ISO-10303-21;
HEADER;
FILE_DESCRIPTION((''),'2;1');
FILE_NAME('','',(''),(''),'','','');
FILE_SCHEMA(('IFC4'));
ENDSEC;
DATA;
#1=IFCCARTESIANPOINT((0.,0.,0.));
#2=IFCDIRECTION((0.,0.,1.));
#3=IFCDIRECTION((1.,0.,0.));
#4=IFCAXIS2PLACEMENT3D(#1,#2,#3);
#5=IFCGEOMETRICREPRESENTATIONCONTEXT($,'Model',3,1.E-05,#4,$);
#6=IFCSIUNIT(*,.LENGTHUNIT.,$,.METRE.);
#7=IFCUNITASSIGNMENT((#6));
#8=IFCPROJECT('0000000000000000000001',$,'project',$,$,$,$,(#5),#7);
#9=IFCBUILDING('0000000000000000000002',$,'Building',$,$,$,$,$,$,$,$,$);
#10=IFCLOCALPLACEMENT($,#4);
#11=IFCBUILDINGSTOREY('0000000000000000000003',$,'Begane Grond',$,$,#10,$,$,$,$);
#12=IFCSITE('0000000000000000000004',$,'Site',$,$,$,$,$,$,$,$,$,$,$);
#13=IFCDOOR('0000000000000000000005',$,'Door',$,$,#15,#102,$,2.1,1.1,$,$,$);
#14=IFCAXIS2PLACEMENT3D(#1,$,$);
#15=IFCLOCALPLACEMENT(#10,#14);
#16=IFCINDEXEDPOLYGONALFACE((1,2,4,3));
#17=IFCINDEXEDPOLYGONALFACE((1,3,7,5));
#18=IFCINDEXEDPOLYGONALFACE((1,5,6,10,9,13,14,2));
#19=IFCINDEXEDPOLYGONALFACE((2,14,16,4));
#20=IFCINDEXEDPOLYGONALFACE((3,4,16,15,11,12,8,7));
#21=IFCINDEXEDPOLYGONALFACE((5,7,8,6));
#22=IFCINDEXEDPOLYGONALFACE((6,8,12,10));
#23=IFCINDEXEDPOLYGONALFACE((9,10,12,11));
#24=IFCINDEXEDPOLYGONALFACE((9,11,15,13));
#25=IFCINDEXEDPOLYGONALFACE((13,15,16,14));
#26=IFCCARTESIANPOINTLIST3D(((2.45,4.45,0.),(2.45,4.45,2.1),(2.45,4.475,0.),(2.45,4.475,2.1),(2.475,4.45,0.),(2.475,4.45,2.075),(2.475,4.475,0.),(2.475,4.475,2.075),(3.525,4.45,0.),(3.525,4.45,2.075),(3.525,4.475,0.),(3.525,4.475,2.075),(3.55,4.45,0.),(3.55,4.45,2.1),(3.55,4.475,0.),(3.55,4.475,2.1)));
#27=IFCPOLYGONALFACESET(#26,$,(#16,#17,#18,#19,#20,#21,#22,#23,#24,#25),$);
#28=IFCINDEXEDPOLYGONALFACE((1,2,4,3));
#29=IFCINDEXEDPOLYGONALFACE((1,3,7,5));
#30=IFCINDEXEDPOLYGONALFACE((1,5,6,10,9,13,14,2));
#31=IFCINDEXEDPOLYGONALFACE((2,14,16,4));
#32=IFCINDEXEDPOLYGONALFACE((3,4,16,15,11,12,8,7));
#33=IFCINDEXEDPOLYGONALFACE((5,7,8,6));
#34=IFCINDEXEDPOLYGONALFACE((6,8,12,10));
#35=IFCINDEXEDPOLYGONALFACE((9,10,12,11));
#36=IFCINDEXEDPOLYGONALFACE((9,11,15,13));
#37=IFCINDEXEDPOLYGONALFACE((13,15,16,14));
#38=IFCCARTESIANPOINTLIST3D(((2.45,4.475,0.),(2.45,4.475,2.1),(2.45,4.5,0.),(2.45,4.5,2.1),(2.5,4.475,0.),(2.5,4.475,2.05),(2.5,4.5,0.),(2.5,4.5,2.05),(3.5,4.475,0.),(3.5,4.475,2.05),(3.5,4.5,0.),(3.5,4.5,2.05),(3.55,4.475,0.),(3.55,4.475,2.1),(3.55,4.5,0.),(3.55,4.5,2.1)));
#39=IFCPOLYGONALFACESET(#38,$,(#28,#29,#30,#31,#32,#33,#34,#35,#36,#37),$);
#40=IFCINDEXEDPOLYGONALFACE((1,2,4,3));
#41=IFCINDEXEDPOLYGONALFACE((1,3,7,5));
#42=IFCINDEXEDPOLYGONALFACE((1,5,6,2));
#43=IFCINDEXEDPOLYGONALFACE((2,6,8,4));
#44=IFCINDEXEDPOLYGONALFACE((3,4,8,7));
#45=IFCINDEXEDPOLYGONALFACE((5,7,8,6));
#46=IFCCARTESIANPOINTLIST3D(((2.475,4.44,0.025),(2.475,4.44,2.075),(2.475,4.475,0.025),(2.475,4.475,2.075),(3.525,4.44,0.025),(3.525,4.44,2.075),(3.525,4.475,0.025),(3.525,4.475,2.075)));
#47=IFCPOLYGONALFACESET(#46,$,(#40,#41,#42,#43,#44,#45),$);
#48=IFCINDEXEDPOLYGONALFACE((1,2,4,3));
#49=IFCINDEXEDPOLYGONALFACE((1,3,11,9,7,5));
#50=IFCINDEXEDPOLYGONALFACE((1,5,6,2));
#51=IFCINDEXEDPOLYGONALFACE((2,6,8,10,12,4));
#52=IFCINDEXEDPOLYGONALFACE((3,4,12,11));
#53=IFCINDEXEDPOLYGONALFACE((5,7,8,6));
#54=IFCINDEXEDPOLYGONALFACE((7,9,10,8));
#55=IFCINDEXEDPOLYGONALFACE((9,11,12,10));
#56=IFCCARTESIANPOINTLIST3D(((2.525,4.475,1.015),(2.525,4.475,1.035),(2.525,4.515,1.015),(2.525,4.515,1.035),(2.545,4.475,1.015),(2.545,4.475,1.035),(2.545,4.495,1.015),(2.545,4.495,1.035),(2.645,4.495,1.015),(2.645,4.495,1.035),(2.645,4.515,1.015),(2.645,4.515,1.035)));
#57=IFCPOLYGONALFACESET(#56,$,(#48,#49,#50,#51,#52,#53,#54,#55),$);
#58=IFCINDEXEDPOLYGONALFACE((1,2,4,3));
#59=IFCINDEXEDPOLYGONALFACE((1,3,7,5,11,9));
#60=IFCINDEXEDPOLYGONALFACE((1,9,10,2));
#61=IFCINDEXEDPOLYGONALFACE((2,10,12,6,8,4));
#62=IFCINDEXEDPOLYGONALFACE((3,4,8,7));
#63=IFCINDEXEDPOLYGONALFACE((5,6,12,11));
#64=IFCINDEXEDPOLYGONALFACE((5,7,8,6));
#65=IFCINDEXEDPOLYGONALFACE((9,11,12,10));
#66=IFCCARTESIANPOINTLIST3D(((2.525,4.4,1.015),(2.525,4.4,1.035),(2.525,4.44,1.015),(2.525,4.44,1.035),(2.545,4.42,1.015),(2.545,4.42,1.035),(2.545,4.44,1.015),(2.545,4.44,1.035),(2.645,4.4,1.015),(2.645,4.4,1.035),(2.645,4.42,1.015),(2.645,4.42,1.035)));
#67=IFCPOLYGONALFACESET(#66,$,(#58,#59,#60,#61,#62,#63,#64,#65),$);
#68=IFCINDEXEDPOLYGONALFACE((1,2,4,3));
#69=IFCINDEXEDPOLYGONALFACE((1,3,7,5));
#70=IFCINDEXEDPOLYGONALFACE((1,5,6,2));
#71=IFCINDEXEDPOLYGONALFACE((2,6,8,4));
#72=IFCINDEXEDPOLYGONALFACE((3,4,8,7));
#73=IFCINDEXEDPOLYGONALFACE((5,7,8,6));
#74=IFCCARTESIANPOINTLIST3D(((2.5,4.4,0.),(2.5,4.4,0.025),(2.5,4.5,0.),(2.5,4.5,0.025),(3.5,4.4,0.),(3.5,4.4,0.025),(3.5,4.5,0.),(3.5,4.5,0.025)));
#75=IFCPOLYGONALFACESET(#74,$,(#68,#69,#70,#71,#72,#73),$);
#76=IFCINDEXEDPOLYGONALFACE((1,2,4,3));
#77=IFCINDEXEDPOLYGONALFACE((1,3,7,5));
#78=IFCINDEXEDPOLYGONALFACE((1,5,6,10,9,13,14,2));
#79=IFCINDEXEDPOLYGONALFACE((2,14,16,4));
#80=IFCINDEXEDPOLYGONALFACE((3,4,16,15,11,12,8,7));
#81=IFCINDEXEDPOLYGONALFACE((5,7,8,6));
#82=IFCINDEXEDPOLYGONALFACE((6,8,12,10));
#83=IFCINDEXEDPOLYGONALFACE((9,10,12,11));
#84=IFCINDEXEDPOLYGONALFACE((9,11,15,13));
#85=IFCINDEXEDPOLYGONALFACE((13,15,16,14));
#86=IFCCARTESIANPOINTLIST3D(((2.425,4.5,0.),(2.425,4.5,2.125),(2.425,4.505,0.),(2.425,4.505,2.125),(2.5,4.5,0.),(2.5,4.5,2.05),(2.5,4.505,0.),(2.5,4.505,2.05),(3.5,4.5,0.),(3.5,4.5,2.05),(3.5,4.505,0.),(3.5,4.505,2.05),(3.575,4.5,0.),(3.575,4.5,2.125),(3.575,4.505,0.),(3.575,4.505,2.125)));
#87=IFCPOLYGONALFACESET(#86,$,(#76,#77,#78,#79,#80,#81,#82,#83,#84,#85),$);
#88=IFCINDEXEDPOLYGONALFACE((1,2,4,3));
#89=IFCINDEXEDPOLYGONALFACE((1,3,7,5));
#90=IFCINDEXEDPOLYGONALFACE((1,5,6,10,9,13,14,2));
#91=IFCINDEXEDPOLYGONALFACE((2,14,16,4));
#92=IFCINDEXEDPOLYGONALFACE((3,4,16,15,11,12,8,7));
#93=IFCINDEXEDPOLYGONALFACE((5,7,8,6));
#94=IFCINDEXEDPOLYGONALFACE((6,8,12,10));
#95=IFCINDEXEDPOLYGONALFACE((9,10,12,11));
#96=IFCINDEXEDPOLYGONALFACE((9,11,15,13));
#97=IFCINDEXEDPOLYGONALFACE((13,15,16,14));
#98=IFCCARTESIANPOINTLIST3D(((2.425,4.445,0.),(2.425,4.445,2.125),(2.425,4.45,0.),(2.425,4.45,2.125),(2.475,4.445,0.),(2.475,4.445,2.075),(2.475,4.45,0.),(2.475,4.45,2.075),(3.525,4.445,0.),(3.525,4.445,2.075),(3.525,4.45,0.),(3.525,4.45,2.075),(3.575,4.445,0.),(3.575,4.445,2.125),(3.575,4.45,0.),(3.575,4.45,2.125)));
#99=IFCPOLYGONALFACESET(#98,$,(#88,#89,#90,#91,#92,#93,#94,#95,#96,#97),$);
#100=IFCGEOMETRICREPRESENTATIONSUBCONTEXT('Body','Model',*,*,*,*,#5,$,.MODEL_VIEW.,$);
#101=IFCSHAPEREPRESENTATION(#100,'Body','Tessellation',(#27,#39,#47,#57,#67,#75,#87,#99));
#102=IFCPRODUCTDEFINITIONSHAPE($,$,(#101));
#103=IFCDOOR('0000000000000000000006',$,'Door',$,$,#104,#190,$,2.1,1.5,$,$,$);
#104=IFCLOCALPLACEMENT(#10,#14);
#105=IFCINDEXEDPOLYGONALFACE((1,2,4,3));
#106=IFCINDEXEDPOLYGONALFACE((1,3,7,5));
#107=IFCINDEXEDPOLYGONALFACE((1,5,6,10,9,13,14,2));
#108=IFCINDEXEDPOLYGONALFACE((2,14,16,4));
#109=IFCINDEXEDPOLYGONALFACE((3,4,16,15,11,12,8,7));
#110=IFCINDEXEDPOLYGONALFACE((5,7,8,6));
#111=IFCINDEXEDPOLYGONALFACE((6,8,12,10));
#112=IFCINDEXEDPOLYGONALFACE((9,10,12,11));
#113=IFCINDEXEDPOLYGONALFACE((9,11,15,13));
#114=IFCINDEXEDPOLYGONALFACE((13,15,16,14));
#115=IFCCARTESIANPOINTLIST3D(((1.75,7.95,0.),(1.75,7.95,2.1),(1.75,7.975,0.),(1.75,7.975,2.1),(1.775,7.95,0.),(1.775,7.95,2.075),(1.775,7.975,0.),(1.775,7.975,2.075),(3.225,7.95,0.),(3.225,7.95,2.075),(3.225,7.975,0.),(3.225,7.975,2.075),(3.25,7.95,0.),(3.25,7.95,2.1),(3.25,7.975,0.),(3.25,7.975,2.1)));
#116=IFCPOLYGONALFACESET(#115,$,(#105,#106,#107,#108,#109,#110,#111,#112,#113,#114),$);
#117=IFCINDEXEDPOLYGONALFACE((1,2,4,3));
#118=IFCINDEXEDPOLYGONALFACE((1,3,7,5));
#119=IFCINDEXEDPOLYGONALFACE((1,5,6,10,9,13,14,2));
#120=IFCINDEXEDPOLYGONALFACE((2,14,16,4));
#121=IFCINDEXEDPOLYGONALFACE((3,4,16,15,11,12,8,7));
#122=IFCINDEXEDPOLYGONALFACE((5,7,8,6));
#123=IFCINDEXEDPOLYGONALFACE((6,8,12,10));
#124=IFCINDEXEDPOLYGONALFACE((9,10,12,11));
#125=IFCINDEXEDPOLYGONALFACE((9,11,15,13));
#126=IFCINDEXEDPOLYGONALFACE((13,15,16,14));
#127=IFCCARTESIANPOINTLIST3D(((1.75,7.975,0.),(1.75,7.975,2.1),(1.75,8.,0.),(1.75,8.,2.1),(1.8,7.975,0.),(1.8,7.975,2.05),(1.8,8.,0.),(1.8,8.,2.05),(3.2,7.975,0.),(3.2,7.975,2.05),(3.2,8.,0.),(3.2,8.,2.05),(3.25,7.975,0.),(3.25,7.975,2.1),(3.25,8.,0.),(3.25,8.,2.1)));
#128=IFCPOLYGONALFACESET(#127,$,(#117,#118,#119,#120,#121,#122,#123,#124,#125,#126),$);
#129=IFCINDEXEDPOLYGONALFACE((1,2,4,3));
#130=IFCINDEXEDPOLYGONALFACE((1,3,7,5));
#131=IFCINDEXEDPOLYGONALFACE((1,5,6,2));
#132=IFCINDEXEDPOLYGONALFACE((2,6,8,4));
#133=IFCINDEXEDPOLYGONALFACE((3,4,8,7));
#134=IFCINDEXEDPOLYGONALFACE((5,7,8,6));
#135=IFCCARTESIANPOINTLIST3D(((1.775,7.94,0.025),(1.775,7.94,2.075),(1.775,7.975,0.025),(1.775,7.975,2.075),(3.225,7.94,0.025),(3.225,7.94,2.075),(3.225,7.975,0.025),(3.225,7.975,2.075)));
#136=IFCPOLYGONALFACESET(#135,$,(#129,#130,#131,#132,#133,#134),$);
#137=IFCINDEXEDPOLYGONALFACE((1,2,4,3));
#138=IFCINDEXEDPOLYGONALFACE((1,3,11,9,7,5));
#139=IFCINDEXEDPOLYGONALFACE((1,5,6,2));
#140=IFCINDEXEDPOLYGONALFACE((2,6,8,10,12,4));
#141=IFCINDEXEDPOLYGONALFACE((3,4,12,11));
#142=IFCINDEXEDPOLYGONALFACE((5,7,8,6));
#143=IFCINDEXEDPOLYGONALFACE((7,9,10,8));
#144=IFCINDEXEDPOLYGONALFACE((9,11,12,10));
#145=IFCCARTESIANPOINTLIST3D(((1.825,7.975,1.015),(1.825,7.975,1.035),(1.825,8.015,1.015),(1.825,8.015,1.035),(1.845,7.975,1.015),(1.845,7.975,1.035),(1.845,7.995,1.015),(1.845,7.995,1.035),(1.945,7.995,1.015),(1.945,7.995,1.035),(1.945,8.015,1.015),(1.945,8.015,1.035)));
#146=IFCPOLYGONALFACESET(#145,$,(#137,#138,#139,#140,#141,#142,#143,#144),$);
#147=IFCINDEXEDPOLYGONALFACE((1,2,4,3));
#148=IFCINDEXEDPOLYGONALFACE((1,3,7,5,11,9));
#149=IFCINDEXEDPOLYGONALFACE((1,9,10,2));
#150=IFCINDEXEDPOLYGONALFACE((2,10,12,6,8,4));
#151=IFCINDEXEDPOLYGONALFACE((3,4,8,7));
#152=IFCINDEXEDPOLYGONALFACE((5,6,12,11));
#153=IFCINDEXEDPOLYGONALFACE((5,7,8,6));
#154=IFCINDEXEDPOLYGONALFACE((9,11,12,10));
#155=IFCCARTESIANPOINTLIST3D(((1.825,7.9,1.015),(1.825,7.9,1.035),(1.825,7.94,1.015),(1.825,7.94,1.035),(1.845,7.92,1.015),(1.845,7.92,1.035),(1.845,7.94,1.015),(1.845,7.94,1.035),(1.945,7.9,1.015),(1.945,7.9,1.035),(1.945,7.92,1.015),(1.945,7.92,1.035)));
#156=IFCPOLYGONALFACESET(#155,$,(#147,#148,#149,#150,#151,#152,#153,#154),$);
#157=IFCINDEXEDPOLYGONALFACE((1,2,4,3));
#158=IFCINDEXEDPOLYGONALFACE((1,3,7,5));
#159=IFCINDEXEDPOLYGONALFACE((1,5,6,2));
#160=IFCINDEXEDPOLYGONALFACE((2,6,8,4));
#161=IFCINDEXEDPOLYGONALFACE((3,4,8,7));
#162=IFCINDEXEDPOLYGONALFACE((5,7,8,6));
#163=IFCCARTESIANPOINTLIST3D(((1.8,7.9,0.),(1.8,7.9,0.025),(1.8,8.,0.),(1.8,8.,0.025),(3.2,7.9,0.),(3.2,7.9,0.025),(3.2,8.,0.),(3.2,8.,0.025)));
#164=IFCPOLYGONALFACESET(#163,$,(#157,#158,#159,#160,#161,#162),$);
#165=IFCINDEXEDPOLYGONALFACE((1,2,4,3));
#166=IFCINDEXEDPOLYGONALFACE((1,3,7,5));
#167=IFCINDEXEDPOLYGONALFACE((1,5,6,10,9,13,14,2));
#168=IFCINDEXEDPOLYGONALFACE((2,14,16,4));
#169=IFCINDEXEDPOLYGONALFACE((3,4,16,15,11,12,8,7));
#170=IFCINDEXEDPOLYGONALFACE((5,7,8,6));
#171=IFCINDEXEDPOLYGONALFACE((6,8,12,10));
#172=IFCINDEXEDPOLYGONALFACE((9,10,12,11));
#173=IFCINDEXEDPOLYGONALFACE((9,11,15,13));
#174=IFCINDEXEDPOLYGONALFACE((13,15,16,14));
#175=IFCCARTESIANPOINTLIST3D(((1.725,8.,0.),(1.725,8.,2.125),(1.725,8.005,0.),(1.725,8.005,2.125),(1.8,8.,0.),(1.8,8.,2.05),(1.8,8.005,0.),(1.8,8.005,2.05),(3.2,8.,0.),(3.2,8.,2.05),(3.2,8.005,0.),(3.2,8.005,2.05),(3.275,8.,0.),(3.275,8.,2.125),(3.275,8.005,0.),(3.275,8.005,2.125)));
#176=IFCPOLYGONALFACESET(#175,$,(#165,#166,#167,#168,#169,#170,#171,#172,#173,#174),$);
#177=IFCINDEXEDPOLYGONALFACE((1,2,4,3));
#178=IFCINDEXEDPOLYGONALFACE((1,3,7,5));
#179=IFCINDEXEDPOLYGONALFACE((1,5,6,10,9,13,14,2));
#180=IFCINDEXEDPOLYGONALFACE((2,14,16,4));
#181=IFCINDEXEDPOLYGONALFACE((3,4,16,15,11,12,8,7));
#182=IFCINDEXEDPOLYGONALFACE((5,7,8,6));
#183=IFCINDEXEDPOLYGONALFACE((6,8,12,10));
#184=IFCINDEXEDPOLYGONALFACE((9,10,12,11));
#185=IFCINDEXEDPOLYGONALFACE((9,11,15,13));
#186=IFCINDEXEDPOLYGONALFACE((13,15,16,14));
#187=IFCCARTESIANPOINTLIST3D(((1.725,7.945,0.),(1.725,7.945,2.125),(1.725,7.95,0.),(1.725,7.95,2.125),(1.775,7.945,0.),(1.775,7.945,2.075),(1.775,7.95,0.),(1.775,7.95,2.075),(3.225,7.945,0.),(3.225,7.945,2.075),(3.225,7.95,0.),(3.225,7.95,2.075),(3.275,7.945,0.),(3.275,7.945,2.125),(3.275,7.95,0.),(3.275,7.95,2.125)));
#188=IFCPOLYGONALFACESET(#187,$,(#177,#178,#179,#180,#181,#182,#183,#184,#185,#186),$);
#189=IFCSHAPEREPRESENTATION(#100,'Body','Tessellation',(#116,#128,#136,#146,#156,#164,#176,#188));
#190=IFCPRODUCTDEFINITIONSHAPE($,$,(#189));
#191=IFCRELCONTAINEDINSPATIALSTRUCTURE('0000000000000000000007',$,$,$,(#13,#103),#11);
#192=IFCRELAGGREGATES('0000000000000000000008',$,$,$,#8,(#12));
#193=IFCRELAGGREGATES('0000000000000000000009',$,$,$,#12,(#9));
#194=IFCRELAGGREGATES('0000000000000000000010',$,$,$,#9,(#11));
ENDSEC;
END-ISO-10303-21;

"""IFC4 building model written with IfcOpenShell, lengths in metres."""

from ifc_helpers import new_model, si_unit, frame, origin_with_axes, place, context, subcontext, project, spatial, line, indexed_curve, outline, extrude, element, save


model = new_model("IFC4")

# Units and contexts
model_context = context("Model", 3, precision=1e-05, world=origin_with_axes())
body_context = subcontext(model_context, "Body", "Model", "MODEL_VIEW")
ifc_project = project(units=[si_unit("LENGTHUNIT", "METRE")], contexts=[model_context])

# Site, building, storey
site = spatial("IfcSite", under=ifc_project, Name="Site")
building = spatial("IfcBuilding", under=site, Name="Building")
storey_placement = place(None, origin_with_axes())
storey = spatial("IfcBuildingStorey", under=building, at=storey_placement, Name="Begane Grond")

# Doors
door_1_placement = place(storey_placement, frame((3.55, 4.5, 0.0), z_axis=(0.0, 0.0, 1.0), x_axis=(-1.0, 0.0, 0.0)))
element("IfcDoor", 1, at=door_1_placement, inside=storey, Name="Door", OverallHeight=2.1, OverallWidth=1.1, context=body_context, shape_type="SweptSolid", body=[
    extrude(outline(indexed_curve([(0.0, 0.0), (0.0, 2.1), (1.1, 2.1), (1.1, 0.0), (1.075, 0.0), (1.075, 2.075), (0.025, 2.075), (0.025, 0.0)], segments=[line(1, 2, 3, 4, 5, 6, 7, 8, 1)])), frame((0.0, 0.025, 0.0), z_axis=(0.0, -1.0, 0.0), x_axis=(1.0, 0.0, 0.0)), (0.0, 0.0, -1.0), 0.025),
    extrude(outline(indexed_curve([(0.0, 0.0), (0.0, 2.1), (1.1, 2.1), (1.1, 0.0), (1.05, 0.0), (1.05, 2.05), (0.05, 2.05), (0.05, 0.0)], segments=[line(1, 2, 3, 4, 5, 6, 7, 8, 1)])), frame((0.0, 0.0, 0.0), z_axis=(0.0, -1.0, 0.0), x_axis=(1.0, 0.0, 0.0)), (0.0, 0.0, -1.0), 0.025),
    extrude(outline(indexed_curve([(0.0, 0.0), (1.05, 0.0), (1.05, 0.035), (0.0, 0.035)], segments=[line(1, 2, 3, 4, 1)])), frame((0.025, 0.025, 0.025), z_axis=(0.0, 0.0, 1.0), x_axis=(1.0, 0.0, 0.0)), (0.0, 0.0, 1.0), 2.05),
    extrude(outline(indexed_curve([(0.0, 0.0), (0.0, -0.04), (-0.12, -0.04), (-0.12, -0.02), (-0.02, -0.02), (-0.02, 0.0)], segments=[line(1, 2, 3, 4, 5, 6, 1)])), frame((1.025, 0.025, 1.015), z_axis=(0.0, 0.0, 1.0), x_axis=(1.0, 0.0, 0.0)), (0.0, 0.0, 1.0), 0.02),
    extrude(outline(indexed_curve([(0.0, 0.0), (0.0, 0.04), (-0.12, 0.04), (-0.12, 0.02), (-0.02, 0.02), (-0.02, 0.0)], segments=[line(1, 2, 3, 4, 5, 6, 1)])), frame((1.025, 0.06, 1.015), z_axis=(0.0, 0.0, 1.0), x_axis=(1.0, 0.0, 0.0)), (0.0, 0.0, 1.0), 0.02),
    extrude(outline(indexed_curve([(0.0, 0.0), (1.0, 0.0), (1.0, 0.1), (0.0, 0.1)], segments=[line(1, 2, 3, 4, 1)])), frame((0.05, 0.0, 0.0), z_axis=(0.0, 0.0, 1.0), x_axis=(1.0, 0.0, 0.0)), (0.0, 0.0, 1.0), 0.025),
    extrude(outline(indexed_curve([(0.0, 0.0), (0.0, 2.125), (1.15, 2.125), (1.15, 0.0), (1.075, 0.0), (1.075, 2.05), (0.075, 2.05), (0.075, 0.0)], segments=[line(1, 2, 3, 4, 5, 6, 7, 8, 1)])), frame((-0.025, -0.005, 0.0), z_axis=(0.0, -1.0, 0.0), x_axis=(1.0, 0.0, 0.0)), (0.0, 0.0, -1.0), 0.005),
    extrude(outline(indexed_curve([(0.0, 0.0), (0.0, 2.125), (1.15, 2.125), (1.15, 0.0), (1.1, 0.0), (1.1, 2.075), (0.05, 2.075), (0.05, 0.0)], segments=[line(1, 2, 3, 4, 5, 6, 7, 8, 1)])), frame((-0.025, 0.05, 0.0), z_axis=(0.0, -1.0, 0.0), x_axis=(1.0, 0.0, 0.0)), (0.0, 0.0, -1.0), 0.005),
])
door_2_placement = place(storey_placement, frame((3.25, 8.0, 0.0), z_axis=(0.0, 0.0, 1.0), x_axis=(-1.0, 0.0, 0.0)))
element("IfcDoor", 2, at=door_2_placement, inside=storey, Name="Door", OverallHeight=2.1, OverallWidth=1.5, context=body_context, shape_type="SweptSolid", body=[
    extrude(outline(indexed_curve([(0.0, 0.0), (0.0, 2.1), (1.5, 2.1), (1.5, 0.0), (1.475, 0.0), (1.475, 2.075), (0.025, 2.075), (0.025, 0.0)], segments=[line(1, 2, 3, 4, 5, 6, 7, 8, 1)])), frame((0.0, 0.025, 0.0), z_axis=(0.0, -1.0, 0.0), x_axis=(1.0, 0.0, 0.0)), (0.0, 0.0, -1.0), 0.025),
    extrude(outline(indexed_curve([(0.0, 0.0), (0.0, 2.1), (1.5, 2.1), (1.5, 0.0), (1.45, 0.0), (1.45, 2.05), (0.05, 2.05), (0.05, 0.0)], segments=[line(1, 2, 3, 4, 5, 6, 7, 8, 1)])), frame((0.0, 0.0, 0.0), z_axis=(0.0, -1.0, 0.0), x_axis=(1.0, 0.0, 0.0)), (0.0, 0.0, -1.0), 0.025),
    extrude(outline(indexed_curve([(0.0, 0.0), (1.45, 0.0), (1.45, 0.035), (0.0, 0.035)], segments=[line(1, 2, 3, 4, 1)])), frame((0.025, 0.025, 0.025), z_axis=(0.0, 0.0, 1.0), x_axis=(1.0, 0.0, 0.0)), (0.0, 0.0, 1.0), 2.05),
    extrude(outline(indexed_curve([(0.0, 0.0), (0.0, -0.04), (-0.12, -0.04), (-0.12, -0.02), (-0.02, -0.02), (-0.02, 0.0)], segments=[line(1, 2, 3, 4, 5, 6, 1)])), frame((1.425, 0.025, 1.015), z_axis=(0.0, 0.0, 1.0), x_axis=(1.0, 0.0, 0.0)), (0.0, 0.0, 1.0), 0.02),
    extrude(outline(indexed_curve([(0.0, 0.0), (0.0, 0.04), (-0.12, 0.04), (-0.12, 0.02), (-0.02, 0.02), (-0.02, 0.0)], segments=[line(1, 2, 3, 4, 5, 6, 1)])), frame((1.425, 0.06, 1.015), z_axis=(0.0, 0.0, 1.0), x_axis=(1.0, 0.0, 0.0)), (0.0, 0.0, 1.0), 0.02),
    extrude(outline(indexed_curve([(0.0, 0.0), (1.4, 0.0), (1.4, 0.1), (0.0, 0.1)], segments=[line(1, 2, 3, 4, 1)])), frame((0.05, 0.0, 0.0), z_axis=(0.0, 0.0, 1.0), x_axis=(1.0, 0.0, 0.0)), (0.0, 0.0, 1.0), 0.025),
    extrude(outline(indexed_curve([(0.0, 0.0), (0.0, 2.125), (1.55, 2.125), (1.55, 0.0), (1.475, 0.0), (1.475, 2.05), (0.075, 2.05), (0.075, 0.0)], segments=[line(1, 2, 3, 4, 5, 6, 7, 8, 1)])), frame((-0.025, -0.005, 0.0), z_axis=(0.0, -1.0, 0.0), x_axis=(1.0, 0.0, 0.0)), (0.0, 0.0, -1.0), 0.005),
    extrude(outline(indexed_curve([(0.0, 0.0), (0.0, 2.125), (1.55, 2.125), (1.55, 0.0), (1.5, 0.0), (1.5, 2.075), (0.05, 2.075), (0.05, 0.0)], segments=[line(1, 2, 3, 4, 5, 6, 7, 8, 1)])), frame((-0.025, 0.05, 0.0), z_axis=(0.0, -1.0, 0.0), x_axis=(1.0, 0.0, 0.0)), (0.0, 0.0, -1.0), 0.005),
])

save(model, "model.ifc")
